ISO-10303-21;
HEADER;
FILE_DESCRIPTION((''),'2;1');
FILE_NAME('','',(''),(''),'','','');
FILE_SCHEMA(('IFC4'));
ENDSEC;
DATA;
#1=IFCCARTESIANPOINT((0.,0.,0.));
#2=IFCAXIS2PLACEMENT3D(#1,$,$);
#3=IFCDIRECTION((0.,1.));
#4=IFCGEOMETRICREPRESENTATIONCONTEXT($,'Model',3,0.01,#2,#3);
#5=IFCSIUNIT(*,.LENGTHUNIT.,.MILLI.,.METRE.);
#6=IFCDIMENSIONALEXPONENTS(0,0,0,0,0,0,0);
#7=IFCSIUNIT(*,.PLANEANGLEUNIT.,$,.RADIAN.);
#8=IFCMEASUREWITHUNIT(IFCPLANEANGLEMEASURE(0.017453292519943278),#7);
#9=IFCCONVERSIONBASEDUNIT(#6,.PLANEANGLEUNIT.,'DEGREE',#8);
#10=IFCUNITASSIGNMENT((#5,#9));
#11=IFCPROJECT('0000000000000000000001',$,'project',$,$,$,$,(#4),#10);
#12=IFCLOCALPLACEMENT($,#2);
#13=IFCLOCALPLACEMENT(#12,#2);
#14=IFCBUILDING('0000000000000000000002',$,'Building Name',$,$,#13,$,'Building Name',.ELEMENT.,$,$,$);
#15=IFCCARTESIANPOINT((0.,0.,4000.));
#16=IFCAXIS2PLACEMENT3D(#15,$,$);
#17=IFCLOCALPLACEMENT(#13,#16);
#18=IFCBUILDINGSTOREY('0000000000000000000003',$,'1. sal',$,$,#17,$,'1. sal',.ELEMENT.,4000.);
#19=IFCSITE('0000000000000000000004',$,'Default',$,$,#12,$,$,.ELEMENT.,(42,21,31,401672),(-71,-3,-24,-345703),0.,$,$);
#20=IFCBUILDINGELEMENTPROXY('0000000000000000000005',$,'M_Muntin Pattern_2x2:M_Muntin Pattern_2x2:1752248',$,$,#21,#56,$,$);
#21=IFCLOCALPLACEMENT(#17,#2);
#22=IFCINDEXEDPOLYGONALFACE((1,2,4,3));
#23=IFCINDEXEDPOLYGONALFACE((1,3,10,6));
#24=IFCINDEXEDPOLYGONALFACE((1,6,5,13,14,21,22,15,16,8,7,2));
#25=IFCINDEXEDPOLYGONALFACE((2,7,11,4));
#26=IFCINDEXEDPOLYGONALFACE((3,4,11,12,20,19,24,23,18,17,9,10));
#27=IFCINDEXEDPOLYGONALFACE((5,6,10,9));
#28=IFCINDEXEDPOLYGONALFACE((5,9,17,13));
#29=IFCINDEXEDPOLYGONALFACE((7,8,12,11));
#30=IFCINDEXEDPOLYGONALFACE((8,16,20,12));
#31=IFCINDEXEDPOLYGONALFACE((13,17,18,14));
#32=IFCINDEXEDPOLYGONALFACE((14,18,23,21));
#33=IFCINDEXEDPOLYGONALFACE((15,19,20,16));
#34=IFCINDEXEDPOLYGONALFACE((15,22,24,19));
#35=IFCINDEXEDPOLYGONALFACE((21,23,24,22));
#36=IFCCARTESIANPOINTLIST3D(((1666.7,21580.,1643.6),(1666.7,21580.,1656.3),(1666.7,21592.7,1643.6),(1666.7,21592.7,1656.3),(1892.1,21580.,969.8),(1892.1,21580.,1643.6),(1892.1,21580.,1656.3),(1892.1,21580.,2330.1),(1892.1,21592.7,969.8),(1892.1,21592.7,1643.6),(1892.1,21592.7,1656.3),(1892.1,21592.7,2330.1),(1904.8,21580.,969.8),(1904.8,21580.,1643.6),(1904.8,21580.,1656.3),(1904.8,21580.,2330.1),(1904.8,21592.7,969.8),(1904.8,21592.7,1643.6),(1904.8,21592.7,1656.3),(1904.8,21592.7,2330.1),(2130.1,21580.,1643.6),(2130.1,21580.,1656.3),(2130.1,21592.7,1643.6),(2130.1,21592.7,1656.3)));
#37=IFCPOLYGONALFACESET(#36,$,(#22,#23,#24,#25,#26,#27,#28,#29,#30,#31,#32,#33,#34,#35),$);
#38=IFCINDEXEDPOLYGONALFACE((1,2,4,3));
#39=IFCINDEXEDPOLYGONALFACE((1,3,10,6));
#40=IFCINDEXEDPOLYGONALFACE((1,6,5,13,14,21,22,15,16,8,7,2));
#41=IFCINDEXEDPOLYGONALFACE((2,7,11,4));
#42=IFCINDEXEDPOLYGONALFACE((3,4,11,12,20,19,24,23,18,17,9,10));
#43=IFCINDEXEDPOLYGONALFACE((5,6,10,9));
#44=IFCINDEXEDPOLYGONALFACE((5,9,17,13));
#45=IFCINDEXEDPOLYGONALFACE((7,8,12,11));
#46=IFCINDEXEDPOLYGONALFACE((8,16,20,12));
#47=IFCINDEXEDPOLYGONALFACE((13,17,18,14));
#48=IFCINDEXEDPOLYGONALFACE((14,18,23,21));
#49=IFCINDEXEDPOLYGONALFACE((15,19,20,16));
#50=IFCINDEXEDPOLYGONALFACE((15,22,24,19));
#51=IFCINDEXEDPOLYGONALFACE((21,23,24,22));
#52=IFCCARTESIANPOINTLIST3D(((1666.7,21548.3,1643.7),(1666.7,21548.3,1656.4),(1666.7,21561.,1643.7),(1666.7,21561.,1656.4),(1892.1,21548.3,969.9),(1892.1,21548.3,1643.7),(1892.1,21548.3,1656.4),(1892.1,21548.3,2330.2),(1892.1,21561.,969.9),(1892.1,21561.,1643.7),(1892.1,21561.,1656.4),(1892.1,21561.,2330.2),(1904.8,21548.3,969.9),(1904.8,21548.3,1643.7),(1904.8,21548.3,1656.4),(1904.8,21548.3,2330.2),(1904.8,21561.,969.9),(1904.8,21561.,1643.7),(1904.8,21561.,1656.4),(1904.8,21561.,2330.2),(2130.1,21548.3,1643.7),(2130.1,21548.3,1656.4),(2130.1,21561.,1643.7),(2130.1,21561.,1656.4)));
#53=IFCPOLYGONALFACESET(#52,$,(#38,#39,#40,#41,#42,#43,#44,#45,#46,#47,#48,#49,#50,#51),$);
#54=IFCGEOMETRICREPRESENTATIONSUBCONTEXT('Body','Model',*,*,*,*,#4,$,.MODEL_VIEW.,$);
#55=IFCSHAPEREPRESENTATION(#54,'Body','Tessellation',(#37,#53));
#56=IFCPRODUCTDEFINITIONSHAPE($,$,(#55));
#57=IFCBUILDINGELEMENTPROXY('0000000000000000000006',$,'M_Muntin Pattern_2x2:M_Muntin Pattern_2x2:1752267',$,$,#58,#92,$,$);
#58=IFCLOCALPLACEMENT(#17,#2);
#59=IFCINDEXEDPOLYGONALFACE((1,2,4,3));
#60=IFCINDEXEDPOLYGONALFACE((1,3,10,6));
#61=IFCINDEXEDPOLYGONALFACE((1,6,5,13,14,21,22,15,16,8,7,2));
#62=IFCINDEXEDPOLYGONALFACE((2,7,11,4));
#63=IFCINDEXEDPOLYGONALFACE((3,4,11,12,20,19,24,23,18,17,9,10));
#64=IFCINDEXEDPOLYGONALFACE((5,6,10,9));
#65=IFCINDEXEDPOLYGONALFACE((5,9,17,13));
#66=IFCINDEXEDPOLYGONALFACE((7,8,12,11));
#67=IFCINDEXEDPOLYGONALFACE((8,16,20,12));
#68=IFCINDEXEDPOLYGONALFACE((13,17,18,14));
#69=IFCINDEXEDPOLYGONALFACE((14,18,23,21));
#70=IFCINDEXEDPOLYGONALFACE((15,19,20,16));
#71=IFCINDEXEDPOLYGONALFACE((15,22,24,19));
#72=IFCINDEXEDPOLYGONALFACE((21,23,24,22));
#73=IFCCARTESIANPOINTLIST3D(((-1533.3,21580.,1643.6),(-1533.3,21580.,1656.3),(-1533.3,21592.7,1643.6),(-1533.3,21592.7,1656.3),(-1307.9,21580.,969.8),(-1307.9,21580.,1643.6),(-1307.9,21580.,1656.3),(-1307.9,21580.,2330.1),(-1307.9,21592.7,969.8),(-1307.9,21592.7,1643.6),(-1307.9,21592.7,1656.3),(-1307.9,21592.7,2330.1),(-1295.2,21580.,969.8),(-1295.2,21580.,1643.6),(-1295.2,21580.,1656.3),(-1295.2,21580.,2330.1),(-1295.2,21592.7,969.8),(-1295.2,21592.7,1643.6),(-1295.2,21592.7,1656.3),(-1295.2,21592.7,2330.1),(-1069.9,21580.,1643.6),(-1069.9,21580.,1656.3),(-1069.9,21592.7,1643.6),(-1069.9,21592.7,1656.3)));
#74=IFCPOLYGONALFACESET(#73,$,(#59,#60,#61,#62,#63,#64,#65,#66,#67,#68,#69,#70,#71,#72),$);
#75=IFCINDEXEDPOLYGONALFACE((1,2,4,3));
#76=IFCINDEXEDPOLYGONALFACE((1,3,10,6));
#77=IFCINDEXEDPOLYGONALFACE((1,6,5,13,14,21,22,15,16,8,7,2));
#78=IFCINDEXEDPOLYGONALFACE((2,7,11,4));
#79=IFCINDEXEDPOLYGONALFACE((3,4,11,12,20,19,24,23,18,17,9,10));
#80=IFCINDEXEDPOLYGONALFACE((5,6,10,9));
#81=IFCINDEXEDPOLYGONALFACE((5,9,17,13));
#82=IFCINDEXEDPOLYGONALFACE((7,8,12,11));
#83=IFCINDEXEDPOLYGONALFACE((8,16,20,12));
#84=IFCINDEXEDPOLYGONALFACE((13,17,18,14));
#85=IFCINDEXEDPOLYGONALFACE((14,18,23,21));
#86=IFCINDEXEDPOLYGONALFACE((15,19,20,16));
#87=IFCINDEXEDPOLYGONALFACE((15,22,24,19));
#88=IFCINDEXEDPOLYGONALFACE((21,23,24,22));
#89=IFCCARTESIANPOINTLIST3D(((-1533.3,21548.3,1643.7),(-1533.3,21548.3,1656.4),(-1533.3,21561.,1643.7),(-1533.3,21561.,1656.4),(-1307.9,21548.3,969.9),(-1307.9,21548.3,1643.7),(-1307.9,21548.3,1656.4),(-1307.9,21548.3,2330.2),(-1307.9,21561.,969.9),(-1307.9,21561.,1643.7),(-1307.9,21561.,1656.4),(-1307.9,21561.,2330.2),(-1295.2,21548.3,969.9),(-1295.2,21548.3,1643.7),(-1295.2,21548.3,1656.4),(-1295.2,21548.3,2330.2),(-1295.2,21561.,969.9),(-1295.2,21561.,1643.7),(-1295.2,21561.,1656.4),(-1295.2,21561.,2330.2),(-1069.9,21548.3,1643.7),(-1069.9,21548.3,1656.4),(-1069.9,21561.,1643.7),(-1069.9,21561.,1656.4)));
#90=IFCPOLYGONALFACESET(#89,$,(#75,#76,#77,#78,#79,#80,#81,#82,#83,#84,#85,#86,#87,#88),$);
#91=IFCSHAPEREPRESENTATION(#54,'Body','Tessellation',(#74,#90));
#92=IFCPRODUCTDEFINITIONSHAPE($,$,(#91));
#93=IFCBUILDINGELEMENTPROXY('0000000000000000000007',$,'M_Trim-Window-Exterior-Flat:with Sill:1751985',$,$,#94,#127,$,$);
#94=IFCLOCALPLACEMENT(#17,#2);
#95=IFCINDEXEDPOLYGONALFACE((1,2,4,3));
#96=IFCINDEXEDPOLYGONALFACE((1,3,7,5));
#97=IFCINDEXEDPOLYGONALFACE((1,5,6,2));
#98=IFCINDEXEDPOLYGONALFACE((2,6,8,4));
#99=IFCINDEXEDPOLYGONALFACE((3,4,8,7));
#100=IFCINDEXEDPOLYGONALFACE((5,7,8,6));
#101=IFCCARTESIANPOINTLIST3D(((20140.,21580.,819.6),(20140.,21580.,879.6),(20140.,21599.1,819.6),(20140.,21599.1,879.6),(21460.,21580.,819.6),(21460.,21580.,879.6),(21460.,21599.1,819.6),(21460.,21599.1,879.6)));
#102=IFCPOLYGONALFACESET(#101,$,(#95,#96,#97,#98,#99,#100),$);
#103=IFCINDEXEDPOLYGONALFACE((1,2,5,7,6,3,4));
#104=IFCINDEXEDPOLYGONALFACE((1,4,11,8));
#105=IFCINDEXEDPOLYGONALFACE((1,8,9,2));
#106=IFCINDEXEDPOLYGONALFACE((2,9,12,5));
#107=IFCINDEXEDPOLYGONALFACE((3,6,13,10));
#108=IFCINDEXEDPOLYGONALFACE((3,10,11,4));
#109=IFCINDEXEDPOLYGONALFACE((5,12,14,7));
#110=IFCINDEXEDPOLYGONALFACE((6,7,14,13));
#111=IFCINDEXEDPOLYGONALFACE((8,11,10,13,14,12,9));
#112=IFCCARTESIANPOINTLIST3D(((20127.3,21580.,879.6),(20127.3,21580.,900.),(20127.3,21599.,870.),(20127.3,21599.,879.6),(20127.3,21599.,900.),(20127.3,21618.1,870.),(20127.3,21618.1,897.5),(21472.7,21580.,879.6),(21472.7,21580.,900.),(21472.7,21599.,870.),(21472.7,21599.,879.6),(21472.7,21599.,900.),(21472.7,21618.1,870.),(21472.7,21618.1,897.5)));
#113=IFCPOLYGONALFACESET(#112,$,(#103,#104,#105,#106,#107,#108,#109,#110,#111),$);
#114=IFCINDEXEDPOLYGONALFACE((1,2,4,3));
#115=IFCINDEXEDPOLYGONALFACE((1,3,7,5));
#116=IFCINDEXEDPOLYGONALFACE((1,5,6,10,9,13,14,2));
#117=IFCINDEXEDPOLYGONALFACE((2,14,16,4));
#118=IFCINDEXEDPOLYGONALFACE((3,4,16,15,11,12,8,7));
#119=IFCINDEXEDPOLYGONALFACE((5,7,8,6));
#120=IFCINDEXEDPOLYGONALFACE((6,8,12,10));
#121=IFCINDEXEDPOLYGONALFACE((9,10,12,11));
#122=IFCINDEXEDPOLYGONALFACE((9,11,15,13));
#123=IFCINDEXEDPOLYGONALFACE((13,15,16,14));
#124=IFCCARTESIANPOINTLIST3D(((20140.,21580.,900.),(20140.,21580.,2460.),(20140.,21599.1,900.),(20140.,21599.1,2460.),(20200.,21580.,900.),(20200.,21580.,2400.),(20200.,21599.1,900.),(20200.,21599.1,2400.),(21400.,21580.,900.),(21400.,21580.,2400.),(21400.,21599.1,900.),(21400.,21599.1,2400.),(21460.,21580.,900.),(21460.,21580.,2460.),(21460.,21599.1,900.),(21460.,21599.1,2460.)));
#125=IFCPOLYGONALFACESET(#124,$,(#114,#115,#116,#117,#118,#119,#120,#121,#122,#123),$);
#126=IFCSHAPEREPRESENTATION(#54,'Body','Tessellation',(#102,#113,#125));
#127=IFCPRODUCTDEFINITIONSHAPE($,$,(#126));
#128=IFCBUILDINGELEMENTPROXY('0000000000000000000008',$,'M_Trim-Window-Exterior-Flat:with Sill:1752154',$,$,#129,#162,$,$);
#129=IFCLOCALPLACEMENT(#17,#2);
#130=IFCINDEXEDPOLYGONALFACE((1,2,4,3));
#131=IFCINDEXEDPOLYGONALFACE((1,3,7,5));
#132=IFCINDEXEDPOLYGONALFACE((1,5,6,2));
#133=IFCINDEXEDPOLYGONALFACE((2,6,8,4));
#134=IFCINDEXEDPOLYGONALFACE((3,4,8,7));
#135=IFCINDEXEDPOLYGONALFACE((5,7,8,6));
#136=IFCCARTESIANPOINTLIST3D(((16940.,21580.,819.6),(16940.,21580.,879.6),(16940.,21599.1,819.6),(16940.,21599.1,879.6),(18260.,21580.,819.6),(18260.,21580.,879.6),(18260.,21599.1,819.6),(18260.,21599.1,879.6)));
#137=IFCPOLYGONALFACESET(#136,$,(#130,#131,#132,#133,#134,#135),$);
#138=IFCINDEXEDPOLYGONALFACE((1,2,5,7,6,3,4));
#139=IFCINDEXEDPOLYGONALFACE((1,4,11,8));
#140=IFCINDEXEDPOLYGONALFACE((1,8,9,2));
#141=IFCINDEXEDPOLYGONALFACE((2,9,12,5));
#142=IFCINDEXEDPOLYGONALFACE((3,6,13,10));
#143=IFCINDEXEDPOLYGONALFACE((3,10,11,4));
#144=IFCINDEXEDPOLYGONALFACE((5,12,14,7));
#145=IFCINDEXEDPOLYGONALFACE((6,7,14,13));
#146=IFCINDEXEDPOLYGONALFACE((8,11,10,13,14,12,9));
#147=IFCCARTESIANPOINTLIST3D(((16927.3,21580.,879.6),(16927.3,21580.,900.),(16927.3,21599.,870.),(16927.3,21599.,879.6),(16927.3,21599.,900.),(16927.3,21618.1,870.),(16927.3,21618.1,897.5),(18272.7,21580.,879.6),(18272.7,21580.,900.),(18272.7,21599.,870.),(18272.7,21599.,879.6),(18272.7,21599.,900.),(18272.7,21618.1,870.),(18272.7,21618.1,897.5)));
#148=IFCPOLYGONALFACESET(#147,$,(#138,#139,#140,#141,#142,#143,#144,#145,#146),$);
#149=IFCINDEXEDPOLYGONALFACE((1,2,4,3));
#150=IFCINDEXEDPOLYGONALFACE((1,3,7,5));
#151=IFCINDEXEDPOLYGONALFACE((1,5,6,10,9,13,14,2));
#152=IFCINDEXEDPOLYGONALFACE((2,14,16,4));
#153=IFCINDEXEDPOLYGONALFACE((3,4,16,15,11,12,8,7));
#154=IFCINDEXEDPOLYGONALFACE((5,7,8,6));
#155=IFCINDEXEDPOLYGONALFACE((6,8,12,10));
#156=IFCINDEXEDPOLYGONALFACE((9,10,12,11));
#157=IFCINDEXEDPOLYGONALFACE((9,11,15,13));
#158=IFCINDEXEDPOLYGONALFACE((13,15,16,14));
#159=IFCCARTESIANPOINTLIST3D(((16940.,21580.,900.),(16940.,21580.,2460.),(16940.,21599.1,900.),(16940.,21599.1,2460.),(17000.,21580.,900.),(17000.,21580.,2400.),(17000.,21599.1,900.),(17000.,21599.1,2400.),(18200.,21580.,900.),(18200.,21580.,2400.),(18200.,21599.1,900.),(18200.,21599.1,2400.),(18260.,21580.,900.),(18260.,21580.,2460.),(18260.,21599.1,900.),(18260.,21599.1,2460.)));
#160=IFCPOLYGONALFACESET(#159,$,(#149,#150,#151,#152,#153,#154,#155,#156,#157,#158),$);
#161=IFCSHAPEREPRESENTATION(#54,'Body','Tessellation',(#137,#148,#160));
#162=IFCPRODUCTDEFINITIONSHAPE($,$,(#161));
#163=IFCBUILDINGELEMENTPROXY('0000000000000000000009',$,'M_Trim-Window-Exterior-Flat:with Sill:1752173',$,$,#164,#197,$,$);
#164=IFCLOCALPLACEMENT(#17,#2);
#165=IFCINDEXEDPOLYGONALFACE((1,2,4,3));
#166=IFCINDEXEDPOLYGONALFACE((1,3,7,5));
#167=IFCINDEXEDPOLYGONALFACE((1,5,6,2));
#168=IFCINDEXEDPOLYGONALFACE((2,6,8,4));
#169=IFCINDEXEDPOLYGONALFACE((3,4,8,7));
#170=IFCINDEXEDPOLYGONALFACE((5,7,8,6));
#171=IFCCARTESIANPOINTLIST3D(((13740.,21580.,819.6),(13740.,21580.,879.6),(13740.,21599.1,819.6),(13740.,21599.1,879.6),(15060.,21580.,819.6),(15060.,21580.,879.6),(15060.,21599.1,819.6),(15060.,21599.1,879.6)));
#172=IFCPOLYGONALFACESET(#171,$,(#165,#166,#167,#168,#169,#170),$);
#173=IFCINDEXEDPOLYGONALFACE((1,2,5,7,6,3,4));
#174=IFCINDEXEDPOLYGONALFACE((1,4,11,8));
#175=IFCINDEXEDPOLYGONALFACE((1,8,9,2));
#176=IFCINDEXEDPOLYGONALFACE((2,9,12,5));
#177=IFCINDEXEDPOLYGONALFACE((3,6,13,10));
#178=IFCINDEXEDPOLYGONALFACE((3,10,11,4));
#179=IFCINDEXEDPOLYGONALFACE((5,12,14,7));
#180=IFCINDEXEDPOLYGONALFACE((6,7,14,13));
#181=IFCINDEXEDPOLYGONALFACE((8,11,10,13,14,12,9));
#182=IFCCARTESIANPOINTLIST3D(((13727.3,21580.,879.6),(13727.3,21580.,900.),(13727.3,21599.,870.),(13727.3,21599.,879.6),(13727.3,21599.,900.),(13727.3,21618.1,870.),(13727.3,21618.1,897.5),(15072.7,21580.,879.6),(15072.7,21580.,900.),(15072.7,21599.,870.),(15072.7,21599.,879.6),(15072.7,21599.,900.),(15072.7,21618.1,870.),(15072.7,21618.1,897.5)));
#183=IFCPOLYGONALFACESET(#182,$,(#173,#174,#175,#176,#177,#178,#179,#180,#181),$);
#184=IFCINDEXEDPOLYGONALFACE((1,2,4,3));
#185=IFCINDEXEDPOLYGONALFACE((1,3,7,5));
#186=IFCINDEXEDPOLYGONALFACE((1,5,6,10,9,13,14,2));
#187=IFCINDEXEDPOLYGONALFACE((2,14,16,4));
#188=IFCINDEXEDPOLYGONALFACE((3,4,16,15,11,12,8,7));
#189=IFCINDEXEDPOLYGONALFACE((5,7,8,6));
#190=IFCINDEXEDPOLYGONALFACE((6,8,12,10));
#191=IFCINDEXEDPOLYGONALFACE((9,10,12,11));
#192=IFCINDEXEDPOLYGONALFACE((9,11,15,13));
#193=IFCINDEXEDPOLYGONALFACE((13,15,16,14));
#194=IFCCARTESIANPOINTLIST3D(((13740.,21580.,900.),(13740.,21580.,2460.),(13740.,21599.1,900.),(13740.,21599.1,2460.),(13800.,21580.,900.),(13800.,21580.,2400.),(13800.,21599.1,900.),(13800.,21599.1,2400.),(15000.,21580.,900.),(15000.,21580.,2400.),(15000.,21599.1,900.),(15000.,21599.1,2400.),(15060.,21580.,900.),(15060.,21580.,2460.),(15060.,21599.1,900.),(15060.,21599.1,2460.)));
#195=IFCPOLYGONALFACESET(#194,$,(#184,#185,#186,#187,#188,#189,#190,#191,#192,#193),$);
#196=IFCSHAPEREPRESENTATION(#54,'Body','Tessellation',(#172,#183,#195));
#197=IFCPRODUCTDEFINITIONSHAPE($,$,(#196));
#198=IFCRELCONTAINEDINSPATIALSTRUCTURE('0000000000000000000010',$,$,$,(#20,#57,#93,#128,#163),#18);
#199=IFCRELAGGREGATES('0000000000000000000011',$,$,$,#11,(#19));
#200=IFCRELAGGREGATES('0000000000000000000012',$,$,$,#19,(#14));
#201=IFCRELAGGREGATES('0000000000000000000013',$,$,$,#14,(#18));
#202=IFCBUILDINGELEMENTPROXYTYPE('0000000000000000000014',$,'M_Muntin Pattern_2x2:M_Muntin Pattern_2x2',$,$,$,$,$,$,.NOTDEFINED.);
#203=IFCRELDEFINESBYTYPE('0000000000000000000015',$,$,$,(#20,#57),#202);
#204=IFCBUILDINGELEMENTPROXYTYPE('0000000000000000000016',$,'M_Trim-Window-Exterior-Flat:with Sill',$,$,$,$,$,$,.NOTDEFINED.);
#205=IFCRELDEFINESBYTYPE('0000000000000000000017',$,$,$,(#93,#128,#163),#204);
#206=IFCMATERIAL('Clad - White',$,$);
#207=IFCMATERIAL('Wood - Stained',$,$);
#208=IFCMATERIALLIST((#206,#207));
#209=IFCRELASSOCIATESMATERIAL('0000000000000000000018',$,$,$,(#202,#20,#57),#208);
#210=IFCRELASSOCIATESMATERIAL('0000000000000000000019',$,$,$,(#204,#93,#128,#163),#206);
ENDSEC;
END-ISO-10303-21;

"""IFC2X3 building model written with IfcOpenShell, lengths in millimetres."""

from ifc_helpers import new_model, entity, si_unit, converted_unit, direction, frame, frame_2d, origin, place, context, subcontext, project, spatial, polyline, rectangle, outline, extrude, source, transform, mapped, material, material_list, type_object, type_shapes, element, save


model = new_model("IFC2X3")

# Units and contexts
model_context = context("Model", 3, precision=0.01, world=origin(), true_north=direction((0.0, 1.0)))
body_context = subcontext(model_context, "Body", "Model", "MODEL_VIEW")
ifc_project = project(units=[si_unit("LENGTHUNIT", "METRE", prefix="MILLI"), converted_unit("PLANEANGLEUNIT", "DEGREE", entity("IfcPlaneAngleMeasure", 0.017453292519943278), si_unit("PLANEANGLEUNIT", "RADIAN"), dimensions=[0, 0, 0, 0, 0, 0, 0])], contexts=[model_context])

# Site, building, storey
site_placement = place(None, origin())
site = spatial("IfcSite", under=ifc_project, at=site_placement, Name="Default", CompositionType="ELEMENT", RefLatitude=(42, 21, 31, 401672), RefLongitude=(-71, -3, -24, -345703), RefElevation=0.0)
building_placement = place(site_placement, origin())
building = spatial("IfcBuilding", under=site, at=building_placement, Name="Building Name", LongName="Building Name", CompositionType="ELEMENT")
storey_placement = place(building_placement, frame((0.0, 0.0, 4000.0)))
storey = spatial("IfcBuildingStorey", under=building, at=storey_placement, Name="1. sal", LongName="1. sal", CompositionType="ELEMENT", Elevation=4000.0)

# Building element proxies
ifc_material_1 = material(Name="Clad - White")
ifc_material_2 = material(Name="Wood - Stained")
ifc_material_list = material_list([ifc_material_1, ifc_material_2])
building_element_proxy_type_1 = type_object("IfcBuildingElementProxyType", Name="M_Muntin Pattern_2x2:M_Muntin Pattern_2x2", PredefinedType="NOTDEFINED", material=ifc_material_list)
shared_shape_1 = source(origin(), body_context, "Body", "SweptSolid", [
    extrude(outline(polyline([(6.4, -6.4), (680.1, -6.4), (680.1, 6.3), (6.4, 6.3), (6.4, 231.7), (-6.3, 231.7), (-6.3, 6.3), (-680.2, 6.3), (-680.2, -6.4), (-6.3, -6.4), (-6.3, -231.7), (6.4, -231.7), (6.4, -6.4)])), frame((0.0, -22.2, 680.1), z_axis=(0.0, 1.0, 0.0), x_axis=(0.0, 0.0, 1.0)), (0.0, 0.0, 1.0), 12.7),
    extrude(outline(polyline([(6.4, -6.4), (680.2, -6.4), (680.2, 6.3), (6.4, 6.3), (6.4, 231.7), (-6.3, 231.7), (-6.3, 6.3), (-680.2, 6.3), (-680.2, -6.4), (-6.3, -6.4), (-6.3, -231.7), (6.4, -231.7), (6.4, -6.4)])), frame((0.0, 9.5, 680.2), z_axis=(0.0, 1.0, 0.0), x_axis=(0.0, 0.0, 1.0)), (0.0, 0.0, 1.0), 12.7),
])
type_shapes(building_element_proxy_type_1, [shared_shape_1])
for number, where, z_axis, x_axis, name in (
    (1, (1898.4, 21570.5, 969.9), (0.0, 0.0, 1.0), (-1.0, 0.0, 0.0), "M_Muntin Pattern_2x2:M_Muntin Pattern_2x2:1752248"),
    (2, (-1301.6, 21570.5, 969.9), (0.0, 0.0, 1.0), (-1.0, 0.0, 0.0), "M_Muntin Pattern_2x2:M_Muntin Pattern_2x2:1752267"),
):
    element("IfcBuildingElementProxy", number, at=place(storey_placement, frame(where, z_axis=z_axis, x_axis=x_axis)), inside=storey, type_object=building_element_proxy_type_1, material=ifc_material_list, Name=name, context=body_context, shape_type="MappedRepresentation", body=[
        mapped(shared_shape_1, transform((0.0, 0.0, 0.0), scale=1.0)),
    ])
building_element_proxy_type_2 = type_object("IfcBuildingElementProxyType", Name="M_Trim-Window-Exterior-Flat:with Sill", PredefinedType="NOTDEFINED", material=ifc_material_1)
shared_shape_2 = source(origin(), body_context, "Body", "SweptSolid", [
    extrude(rectangle(XDim=1320.0, YDim=60.0, at=frame_2d((0.0, 0.0), x_axis=(1.0, 0.0))), frame((0.0, -1550.4, 0.0), z_axis=(0.0, 0.0, 1.0), x_axis=(-1.0, 0.0, 0.0)), (0.0, 0.0, 1.0), 19.0),
    extrude(outline(polyline([(-19.0, -15.2), (0.0, -15.2), (0.0, -5.7), (19.0, -5.7), (19.0, 14.8), (0.0, 14.8), (-19.0, 12.3), (-19.0, -15.2)])), frame((-672.7, -1514.8, 19.0), z_axis=(1.0, 0.0, 0.0), x_axis=(0.0, 0.0, -1.0)), (0.0, 0.0, 1.0), 1345.4),
    extrude(outline(polyline([(-795.0, -660.0), (765.0, -660.0), (765.0, -600.0), (-735.0, -600.0), (-735.0, 600.0), (765.0, 600.0), (765.0, 660.0), (-795.0, 660.0), (-795.0, -660.0)])), frame((0.0, -735.0, 0.0), z_axis=(0.0, 0.0, 1.0), x_axis=(0.0, -1.0, 0.0)), (0.0, 0.0, 1.0), 19.0),
])
type_shapes(building_element_proxy_type_2, [shared_shape_2])
for number, where, z_axis, x_axis, name in (
    (3, (20800.0, 21580.0, 2400.0), (0.0, 1.0, 0.0), (-1.0, 0.0, 0.0), "M_Trim-Window-Exterior-Flat:with Sill:1751985"),
    (4, (17600.0, 21580.0, 2400.0), (0.0, 1.0, 0.0), (-1.0, 0.0, 0.0), "M_Trim-Window-Exterior-Flat:with Sill:1752154"),
    (5, (14400.0, 21580.0, 2400.0), (0.0, 1.0, 0.0), (-1.0, 0.0, 0.0), "M_Trim-Window-Exterior-Flat:with Sill:1752173"),
):
    element("IfcBuildingElementProxy", number, at=place(storey_placement, frame(where, z_axis=z_axis, x_axis=x_axis)), inside=storey, type_object=building_element_proxy_type_2, material=ifc_material_1, Name=name, context=body_context, shape_type="MappedRepresentation", body=[
        mapped(shared_shape_2, transform((0.0, 0.0, 0.0), scale=1.0)),
    ])

save(model, "model.ifc")
